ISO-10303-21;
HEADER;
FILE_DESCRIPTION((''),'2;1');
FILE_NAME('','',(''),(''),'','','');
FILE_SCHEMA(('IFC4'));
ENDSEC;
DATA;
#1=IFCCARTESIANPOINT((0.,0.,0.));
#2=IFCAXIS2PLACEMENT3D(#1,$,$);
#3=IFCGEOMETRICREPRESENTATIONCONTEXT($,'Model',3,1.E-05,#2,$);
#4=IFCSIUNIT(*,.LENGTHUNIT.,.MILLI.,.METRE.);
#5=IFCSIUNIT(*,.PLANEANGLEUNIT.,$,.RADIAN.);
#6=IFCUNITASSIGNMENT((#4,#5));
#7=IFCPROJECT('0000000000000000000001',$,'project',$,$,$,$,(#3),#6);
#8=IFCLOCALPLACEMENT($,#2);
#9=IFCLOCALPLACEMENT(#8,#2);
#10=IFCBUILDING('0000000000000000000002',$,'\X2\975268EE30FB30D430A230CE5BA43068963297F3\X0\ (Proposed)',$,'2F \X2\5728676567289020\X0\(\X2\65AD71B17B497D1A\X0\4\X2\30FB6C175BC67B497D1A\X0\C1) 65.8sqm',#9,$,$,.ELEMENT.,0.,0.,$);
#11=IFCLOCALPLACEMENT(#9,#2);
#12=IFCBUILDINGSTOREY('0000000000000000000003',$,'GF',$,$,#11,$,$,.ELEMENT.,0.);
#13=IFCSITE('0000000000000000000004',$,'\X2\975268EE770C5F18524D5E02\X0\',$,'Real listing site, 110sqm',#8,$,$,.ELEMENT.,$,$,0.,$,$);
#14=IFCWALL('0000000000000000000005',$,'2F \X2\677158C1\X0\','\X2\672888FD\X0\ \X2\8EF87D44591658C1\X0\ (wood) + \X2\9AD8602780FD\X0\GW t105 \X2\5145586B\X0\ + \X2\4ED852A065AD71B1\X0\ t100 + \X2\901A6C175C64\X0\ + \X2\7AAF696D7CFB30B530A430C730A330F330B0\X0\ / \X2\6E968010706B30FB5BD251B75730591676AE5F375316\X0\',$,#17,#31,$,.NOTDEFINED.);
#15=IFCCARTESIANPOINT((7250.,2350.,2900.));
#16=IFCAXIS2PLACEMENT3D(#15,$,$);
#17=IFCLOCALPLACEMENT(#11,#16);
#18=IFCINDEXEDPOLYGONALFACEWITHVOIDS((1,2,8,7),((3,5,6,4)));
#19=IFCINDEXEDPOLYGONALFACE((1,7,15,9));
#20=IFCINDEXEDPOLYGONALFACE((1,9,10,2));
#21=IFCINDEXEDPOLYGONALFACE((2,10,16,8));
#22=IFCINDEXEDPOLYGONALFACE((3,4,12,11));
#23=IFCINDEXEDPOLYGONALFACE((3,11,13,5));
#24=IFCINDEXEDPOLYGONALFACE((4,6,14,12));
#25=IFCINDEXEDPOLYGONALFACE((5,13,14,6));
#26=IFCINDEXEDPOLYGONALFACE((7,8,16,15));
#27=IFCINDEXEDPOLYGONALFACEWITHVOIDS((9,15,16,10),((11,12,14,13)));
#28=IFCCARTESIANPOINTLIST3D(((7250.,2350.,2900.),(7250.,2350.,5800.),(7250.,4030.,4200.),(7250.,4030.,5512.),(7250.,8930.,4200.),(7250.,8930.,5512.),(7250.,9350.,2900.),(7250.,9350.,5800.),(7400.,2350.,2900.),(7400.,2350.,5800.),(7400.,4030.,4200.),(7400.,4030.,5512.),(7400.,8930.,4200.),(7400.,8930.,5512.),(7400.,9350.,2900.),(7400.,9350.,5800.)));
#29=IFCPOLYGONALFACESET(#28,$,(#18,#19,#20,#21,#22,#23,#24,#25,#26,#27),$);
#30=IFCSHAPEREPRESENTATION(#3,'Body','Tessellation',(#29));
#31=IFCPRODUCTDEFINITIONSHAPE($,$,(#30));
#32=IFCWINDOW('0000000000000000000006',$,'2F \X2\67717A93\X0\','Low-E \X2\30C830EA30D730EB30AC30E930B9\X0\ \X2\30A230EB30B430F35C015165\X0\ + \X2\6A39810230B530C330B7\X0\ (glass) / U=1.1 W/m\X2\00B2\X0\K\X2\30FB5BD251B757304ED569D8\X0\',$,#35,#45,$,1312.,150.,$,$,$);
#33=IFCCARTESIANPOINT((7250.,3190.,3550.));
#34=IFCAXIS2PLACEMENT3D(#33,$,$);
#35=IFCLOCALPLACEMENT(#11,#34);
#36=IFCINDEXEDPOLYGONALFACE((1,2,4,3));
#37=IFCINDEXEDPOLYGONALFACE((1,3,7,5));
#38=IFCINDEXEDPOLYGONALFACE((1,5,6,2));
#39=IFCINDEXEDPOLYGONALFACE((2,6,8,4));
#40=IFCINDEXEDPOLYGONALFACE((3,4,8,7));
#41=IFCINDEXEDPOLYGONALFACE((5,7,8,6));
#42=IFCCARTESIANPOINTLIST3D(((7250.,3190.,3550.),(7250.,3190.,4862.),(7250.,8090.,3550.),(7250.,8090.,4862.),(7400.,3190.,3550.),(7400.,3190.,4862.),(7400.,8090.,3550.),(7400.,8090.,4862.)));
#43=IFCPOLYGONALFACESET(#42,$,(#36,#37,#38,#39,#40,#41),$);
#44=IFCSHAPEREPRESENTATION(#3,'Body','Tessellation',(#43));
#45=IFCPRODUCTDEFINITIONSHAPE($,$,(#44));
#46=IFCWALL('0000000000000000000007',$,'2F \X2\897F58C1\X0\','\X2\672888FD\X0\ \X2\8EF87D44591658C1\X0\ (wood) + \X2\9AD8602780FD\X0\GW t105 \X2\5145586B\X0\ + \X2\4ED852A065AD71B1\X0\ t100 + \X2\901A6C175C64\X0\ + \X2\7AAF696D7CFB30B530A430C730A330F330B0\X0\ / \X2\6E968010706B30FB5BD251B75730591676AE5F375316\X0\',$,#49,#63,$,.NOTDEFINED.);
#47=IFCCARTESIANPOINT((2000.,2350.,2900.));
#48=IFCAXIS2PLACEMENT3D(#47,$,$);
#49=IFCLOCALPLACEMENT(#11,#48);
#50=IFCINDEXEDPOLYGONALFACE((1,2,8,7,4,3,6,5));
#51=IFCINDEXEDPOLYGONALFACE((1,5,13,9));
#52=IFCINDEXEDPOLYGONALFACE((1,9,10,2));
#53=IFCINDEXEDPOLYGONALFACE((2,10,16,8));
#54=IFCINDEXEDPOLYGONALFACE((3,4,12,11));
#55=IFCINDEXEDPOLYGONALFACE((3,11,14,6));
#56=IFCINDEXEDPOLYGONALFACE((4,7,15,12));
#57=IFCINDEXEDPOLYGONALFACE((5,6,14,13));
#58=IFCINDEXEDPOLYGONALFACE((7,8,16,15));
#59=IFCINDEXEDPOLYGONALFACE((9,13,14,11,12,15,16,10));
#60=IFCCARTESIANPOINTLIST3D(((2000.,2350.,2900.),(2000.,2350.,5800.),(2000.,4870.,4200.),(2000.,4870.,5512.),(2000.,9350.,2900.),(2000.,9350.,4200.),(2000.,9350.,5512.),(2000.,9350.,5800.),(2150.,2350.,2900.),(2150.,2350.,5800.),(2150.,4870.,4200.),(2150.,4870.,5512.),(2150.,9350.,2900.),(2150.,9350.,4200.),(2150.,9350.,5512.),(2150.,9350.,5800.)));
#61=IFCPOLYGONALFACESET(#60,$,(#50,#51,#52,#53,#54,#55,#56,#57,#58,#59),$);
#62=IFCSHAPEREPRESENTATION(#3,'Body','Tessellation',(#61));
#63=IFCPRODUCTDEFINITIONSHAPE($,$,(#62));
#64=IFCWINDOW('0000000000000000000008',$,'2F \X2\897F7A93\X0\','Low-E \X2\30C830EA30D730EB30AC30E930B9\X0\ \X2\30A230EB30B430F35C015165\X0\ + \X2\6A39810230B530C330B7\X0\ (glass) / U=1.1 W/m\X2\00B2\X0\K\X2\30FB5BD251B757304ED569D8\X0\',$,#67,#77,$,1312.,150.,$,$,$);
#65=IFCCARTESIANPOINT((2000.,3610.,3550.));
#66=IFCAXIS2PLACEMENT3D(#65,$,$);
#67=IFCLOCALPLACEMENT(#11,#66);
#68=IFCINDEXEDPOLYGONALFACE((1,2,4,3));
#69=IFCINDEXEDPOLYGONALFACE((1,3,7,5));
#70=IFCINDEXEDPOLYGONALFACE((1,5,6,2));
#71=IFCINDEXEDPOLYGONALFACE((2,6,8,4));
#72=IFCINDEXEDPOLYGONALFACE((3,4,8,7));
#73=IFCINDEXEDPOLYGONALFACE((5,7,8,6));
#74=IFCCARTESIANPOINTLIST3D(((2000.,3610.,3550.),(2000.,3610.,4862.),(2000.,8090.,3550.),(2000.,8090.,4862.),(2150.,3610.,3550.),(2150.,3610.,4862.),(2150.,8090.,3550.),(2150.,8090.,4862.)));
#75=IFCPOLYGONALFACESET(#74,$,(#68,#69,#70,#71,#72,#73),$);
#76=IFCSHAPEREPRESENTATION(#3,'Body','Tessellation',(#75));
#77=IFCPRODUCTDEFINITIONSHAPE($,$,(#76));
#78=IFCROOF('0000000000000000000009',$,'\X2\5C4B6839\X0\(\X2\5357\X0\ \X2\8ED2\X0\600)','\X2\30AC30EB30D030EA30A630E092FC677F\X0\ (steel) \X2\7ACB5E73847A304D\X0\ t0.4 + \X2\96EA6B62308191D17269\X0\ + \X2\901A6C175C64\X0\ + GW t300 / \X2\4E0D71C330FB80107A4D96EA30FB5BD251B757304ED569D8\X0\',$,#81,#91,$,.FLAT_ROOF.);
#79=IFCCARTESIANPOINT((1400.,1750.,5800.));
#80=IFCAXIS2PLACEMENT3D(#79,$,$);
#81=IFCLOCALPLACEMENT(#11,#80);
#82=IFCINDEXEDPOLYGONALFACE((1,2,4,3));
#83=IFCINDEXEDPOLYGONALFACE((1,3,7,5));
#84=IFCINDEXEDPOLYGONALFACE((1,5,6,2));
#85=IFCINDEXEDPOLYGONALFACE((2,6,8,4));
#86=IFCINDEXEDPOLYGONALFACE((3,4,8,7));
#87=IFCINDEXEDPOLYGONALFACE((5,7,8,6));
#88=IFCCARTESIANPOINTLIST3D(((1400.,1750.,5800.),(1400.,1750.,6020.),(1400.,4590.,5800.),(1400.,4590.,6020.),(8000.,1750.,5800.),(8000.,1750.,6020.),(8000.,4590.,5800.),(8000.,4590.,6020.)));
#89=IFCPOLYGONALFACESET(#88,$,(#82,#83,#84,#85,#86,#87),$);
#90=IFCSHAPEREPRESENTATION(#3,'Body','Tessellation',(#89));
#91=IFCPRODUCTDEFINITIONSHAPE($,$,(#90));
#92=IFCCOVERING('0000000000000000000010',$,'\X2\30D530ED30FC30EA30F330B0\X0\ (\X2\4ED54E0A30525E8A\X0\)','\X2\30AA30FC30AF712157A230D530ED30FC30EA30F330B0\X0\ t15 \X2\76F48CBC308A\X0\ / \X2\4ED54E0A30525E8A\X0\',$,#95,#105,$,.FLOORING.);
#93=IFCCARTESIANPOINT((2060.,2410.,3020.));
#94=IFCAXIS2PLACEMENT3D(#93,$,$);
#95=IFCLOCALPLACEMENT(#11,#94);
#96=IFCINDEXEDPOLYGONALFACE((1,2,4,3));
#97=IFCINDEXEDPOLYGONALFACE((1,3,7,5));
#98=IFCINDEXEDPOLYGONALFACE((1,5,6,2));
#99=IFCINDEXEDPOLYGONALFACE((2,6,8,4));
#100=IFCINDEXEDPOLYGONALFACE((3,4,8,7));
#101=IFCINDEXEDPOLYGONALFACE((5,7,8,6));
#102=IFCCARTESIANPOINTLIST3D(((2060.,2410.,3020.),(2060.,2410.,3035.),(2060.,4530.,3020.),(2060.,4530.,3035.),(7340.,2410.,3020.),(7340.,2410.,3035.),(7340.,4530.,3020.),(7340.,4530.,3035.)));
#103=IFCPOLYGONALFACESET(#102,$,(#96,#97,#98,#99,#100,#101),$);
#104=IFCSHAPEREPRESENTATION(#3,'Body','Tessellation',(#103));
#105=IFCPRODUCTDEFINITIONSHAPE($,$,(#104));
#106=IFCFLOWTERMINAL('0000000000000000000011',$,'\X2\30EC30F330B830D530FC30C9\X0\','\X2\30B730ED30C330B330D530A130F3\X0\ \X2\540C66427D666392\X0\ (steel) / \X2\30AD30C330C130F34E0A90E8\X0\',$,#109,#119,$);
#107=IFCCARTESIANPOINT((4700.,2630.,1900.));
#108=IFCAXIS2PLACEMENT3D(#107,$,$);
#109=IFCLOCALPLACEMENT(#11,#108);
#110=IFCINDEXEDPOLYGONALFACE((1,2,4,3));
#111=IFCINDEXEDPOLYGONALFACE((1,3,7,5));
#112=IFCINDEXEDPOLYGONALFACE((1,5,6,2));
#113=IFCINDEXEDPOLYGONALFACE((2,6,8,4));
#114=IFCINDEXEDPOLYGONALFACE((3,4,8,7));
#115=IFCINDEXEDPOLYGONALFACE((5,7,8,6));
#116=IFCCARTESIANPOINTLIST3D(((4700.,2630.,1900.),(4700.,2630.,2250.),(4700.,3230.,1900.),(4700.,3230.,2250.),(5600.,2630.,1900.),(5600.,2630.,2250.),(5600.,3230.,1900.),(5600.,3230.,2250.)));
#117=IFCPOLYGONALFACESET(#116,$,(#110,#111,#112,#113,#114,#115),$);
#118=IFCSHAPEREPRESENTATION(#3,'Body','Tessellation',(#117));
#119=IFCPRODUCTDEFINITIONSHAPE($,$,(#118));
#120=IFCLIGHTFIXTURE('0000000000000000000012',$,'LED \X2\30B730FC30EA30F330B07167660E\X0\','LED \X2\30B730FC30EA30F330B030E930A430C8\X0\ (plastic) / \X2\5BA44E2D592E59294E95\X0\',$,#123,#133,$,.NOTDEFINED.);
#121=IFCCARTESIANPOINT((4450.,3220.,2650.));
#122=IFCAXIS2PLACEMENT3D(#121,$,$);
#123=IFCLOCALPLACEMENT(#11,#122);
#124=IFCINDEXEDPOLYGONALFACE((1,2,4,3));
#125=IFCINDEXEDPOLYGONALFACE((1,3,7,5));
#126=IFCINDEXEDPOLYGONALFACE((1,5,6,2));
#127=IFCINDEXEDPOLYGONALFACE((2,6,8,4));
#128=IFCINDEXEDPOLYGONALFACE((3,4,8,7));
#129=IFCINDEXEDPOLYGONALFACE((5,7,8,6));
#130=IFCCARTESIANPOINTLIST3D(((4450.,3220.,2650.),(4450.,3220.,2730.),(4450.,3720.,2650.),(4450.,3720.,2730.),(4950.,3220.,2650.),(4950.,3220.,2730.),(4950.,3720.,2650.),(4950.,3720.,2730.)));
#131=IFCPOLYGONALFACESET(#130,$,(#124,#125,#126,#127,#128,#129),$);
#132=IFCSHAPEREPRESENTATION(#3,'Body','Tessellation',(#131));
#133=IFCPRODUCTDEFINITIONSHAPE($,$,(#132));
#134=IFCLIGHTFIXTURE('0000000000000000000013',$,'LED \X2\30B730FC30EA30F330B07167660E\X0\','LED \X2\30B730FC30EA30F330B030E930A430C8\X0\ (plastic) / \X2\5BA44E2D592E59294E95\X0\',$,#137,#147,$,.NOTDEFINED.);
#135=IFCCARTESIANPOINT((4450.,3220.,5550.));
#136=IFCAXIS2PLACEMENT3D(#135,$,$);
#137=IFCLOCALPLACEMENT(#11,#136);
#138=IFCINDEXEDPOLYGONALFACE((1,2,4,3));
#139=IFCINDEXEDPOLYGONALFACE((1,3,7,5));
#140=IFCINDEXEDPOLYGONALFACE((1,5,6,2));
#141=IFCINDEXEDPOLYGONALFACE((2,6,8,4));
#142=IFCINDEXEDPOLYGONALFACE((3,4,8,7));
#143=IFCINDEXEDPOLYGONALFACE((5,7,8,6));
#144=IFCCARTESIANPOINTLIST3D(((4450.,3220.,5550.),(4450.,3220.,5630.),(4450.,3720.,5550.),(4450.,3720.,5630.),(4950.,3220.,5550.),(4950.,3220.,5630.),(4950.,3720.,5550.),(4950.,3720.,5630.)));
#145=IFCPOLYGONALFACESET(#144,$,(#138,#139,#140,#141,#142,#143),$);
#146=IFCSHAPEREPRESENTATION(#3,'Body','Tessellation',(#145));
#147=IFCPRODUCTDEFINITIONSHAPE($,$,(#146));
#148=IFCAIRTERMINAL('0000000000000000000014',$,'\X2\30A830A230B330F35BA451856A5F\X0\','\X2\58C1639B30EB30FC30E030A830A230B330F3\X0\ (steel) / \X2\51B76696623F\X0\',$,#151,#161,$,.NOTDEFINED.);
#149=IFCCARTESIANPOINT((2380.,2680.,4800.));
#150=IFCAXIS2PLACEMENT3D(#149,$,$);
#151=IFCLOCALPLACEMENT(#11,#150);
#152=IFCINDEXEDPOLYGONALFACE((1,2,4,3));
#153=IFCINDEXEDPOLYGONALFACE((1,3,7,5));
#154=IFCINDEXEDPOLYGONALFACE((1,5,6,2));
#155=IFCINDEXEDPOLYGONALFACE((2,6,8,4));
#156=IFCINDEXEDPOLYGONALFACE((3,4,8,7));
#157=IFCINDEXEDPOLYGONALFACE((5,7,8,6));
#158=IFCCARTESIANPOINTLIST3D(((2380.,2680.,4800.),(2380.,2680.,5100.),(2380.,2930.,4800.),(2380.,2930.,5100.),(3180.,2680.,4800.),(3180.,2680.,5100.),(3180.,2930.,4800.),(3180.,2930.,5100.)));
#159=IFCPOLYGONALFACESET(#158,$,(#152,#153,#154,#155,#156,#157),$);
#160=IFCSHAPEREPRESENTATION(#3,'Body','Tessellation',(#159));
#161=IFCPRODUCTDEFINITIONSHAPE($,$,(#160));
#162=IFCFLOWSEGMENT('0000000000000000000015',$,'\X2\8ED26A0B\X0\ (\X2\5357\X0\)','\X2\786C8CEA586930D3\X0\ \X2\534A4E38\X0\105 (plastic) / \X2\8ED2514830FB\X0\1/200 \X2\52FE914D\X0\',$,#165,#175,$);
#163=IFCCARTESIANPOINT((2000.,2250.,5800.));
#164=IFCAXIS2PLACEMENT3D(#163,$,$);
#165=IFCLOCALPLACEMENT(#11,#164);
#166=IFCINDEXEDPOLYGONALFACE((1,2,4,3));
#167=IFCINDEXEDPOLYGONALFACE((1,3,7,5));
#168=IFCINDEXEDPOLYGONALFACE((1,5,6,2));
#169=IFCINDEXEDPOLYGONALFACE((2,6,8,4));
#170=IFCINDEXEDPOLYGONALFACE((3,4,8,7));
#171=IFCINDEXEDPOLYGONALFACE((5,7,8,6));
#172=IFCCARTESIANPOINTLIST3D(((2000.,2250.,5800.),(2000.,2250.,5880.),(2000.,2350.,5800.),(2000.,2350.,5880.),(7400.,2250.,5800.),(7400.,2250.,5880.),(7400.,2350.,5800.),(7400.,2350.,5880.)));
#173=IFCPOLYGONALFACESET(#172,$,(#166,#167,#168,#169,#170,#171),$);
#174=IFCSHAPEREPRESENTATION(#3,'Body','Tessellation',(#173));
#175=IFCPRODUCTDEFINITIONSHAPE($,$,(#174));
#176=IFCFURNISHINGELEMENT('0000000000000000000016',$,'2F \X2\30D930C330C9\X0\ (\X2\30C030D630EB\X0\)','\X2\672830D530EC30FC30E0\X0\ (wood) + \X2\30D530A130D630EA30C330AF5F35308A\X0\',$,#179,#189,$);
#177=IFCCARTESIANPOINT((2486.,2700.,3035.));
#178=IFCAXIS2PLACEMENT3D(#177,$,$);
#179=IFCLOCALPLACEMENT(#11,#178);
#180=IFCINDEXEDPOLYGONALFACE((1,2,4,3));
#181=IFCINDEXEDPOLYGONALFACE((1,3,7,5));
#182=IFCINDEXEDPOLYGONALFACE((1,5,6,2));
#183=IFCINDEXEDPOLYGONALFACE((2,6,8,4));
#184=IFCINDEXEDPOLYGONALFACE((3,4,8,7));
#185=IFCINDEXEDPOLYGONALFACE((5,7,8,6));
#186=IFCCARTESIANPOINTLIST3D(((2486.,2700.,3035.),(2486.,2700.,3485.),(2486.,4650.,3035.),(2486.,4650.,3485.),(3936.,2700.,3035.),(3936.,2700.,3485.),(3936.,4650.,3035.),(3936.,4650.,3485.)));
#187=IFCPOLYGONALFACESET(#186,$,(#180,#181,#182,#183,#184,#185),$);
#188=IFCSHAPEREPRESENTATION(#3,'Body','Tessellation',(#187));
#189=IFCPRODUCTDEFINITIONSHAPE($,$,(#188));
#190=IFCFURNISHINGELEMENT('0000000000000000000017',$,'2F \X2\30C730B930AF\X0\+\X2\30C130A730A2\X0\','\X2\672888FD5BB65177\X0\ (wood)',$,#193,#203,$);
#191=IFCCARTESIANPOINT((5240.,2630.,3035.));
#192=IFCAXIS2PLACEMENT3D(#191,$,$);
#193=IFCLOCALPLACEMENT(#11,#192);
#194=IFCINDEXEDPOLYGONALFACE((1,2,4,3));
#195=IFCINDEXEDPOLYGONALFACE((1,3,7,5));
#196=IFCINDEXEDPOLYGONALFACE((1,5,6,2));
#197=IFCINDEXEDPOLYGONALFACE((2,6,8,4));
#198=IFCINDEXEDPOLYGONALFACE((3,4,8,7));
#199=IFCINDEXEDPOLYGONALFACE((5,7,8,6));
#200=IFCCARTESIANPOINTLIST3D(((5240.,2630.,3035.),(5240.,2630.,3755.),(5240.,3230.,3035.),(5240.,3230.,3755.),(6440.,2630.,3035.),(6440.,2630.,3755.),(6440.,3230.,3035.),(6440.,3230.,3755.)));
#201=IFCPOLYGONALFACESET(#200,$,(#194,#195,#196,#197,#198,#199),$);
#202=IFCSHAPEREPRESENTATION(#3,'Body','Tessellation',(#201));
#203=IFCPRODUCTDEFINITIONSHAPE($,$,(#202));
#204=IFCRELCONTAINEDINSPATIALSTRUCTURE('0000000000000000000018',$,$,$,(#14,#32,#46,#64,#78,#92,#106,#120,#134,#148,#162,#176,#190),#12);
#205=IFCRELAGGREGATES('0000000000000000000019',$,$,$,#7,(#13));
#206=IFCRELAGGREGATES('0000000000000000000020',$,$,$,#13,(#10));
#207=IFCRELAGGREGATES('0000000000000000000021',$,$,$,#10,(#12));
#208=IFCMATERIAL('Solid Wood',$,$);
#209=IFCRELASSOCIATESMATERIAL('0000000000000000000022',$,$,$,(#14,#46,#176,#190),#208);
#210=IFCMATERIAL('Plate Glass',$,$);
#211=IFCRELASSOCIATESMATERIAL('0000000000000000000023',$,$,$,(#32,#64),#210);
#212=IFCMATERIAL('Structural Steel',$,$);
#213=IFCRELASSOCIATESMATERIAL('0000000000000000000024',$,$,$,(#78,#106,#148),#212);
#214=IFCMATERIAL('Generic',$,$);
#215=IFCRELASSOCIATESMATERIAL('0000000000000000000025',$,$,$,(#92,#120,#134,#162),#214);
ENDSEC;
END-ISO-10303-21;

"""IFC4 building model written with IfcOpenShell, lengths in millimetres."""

from ifc_helpers import new_model, si_unit, frame, frame_2d, origin, place, context, project, spatial, rectangle, extrude, material, element, fill, save


model = new_model("IFC4")

# Units and contexts
model_context = context("Model", 3, precision=1e-05, world=origin())
ifc_project = project(units=[si_unit("LENGTHUNIT", "METRE", prefix="MILLI"), si_unit("PLANEANGLEUNIT", "RADIAN")], contexts=[model_context])

# Site, building, storey
site_placement = place(None, origin())
site = spatial("IfcSite", under=ifc_project, at=site_placement, Name="青森県弘前市", ObjectType="Real listing site, 110sqm", CompositionType="ELEMENT", RefElevation=0.0)
building_placement = place(site_placement, origin())
building = spatial("IfcBuilding", under=site, at=building_placement, Name="青森・ピアノ室と防音 (Proposed)", ObjectType="2F 在来木造(断熱等級4・気密等級C1) 65.8sqm", CompositionType="ELEMENT", ElevationOfRefHeight=0.0, ElevationOfTerrain=0.0)
storey_placement = place(building_placement, origin())
storey = spatial("IfcBuildingStorey", under=building, at=storey_placement, Name="GF", CompositionType="ELEMENT", Elevation=0.0)

# Shared definitions
ifc_material_1 = material(Name="Solid Wood")

# Shared definitions
ifc_material_2 = material(Name="Plate Glass")

# Walls, openings, windows
wall_1_placement = place(storey_placement, frame((7250.0, 2350.0, 2900.0)))
wall_1 = element("IfcWall", 1, at=wall_1_placement, inside=storey, material=ifc_material_1, Name="2F 東壁", Description="木製 軸組外壁 (wood) + 高性能GW t105 充填 + 付加断熱 t100 + 通気層 + 窯業系サイディング / 準耐火・寒冷地外皮強化", PredefinedType="NOTDEFINED", context=model_context, shape_type="SweptSolid", body=[
    extrude(rectangle(XDim=150.0, YDim=7000.0, at=frame_2d((75.0, 3500.0))), frame((7250.0, 2350.0, 2900.0)), (0.0, 0.0, 1.0), 2900.0),
])
opening_1_placement = place(storey_placement, frame((7250.0, 3190.0, 3550.0)))
opening_1 = element("IfcOpeningElement", 2, at=opening_1_placement, cuts=wall_1, PredefinedType="NOTDEFINED", context=model_context, shape_type="SweptSolid", body=[
    extrude(rectangle(XDim=150.0, YDim=4900.0, at=frame_2d((75.0, 2450.0))), frame((7250.0, 3190.0, 3550.0)), (0.0, 0.0, 1.0), 1312.0),
])
window_1_placement = place(storey_placement, frame((7250.0, 3190.0, 3550.0)))
window_1 = element("IfcWindow", 3, at=window_1_placement, inside=storey, material=ifc_material_2, Name="2F 東窓", Description="Low-E トリプルガラス アルゴン封入 + 樹脂サッシ (glass) / U=1.1 W/m²K・寒冷地仕様", OverallHeight=1312.0, OverallWidth=150.0, context=model_context, shape_type="SweptSolid", body=[
    extrude(rectangle(XDim=150.0, YDim=4900.0, at=frame_2d((75.0, 2450.0))), frame((7250.0, 3190.0, 3550.0)), (0.0, 0.0, 1.0), 1312.0),
])
fill(opening_1, window_1)
wall_2_placement = place(storey_placement, frame((2000.0, 2350.0, 2900.0)))
wall_2 = element("IfcWall", 4, at=wall_2_placement, inside=storey, material=ifc_material_1, Name="2F 西壁", Description="木製 軸組外壁 (wood) + 高性能GW t105 充填 + 付加断熱 t100 + 通気層 + 窯業系サイディング / 準耐火・寒冷地外皮強化", PredefinedType="NOTDEFINED", context=model_context, shape_type="SweptSolid", body=[
    extrude(rectangle(XDim=150.0, YDim=7000.0, at=frame_2d((75.0, 3500.0))), frame((2000.0, 2350.0, 2900.0)), (0.0, 0.0, 1.0), 2900.0),
])
opening_2_placement = place(storey_placement, frame((2000.0, 3610.0, 3550.0)))
opening_2 = element("IfcOpeningElement", 5, at=opening_2_placement, cuts=wall_2, PredefinedType="NOTDEFINED", context=model_context, shape_type="SweptSolid", body=[
    extrude(rectangle(XDim=150.0, YDim=4480.0, at=frame_2d((75.0, 2240.0))), frame((2000.0, 3610.0, 3550.0)), (0.0, 0.0, 1.0), 1312.0),
])
window_2_placement = place(storey_placement, frame((2000.0, 3610.0, 3550.0)))
window_2 = element("IfcWindow", 6, at=window_2_placement, inside=storey, material=ifc_material_2, Name="2F 西窓", Description="Low-E トリプルガラス アルゴン封入 + 樹脂サッシ (glass) / U=1.1 W/m²K・寒冷地仕様", OverallHeight=1312.0, OverallWidth=150.0, context=model_context, shape_type="SweptSolid", body=[
    extrude(rectangle(XDim=150.0, YDim=4480.0, at=frame_2d((75.0, 2240.0))), frame((2000.0, 3610.0, 3550.0)), (0.0, 0.0, 1.0), 1312.0),
])
fill(opening_2, window_2)

# Roof
ifc_material_3 = material(Name="Structural Steel")
for number, where, name in (
    (7, (1400.0, 1750.0, 5800.0), "屋根(南 軒600)"),
):
    element("IfcRoof", number, at=place(storey_placement, frame(where)), inside=storey, material=ifc_material_3, Name=name, Description="ガルバリウム鋼板 (steel) 立平葺き t0.4 + 雪止め金物 + 通気層 + GW t300 / 不燃・耐積雪・寒冷地仕様", PredefinedType="FLAT_ROOF", context=model_context, shape_type="SweptSolid", body=[
        extrude(rectangle(XDim=6600.0, YDim=2840.0, at=frame_2d((3300.0, 1420.0))), frame((1400.0, 1750.0, 5800.0)), (0.0, 0.0, 1.0), 220.0),
    ])

# Covering
ifc_material_4 = material(Name="Generic")
covering_placement = place(storey_placement, frame((2060.0, 2410.0, 3020.0)))
element("IfcCovering", 8, at=covering_placement, inside=storey, material=ifc_material_4, Name="フローリング (仕上げ床)", Description="オーク無垢フローリング t15 直貼り / 仕上げ床", PredefinedType="FLOORING", context=model_context, shape_type="SweptSolid", body=[
    extrude(rectangle(XDim=5280.0, YDim=2120.0, at=frame_2d((2640.0, 1060.0))), frame((2060.0, 2410.0, 3020.0)), (0.0, 0.0, 1.0), 15.0),
])

# Flow terminal
flow_terminal_placement = place(storey_placement, frame((4700.0, 2630.0, 1900.0)))
element("IfcFlowTerminal", 9, at=flow_terminal_placement, inside=storey, material=ifc_material_3, Name="レンジフード", Description="シロッコファン 同時給排 (steel) / キッチン上部", context=model_context, shape_type="SweptSolid", body=[
    extrude(rectangle(XDim=900.0, YDim=600.0, at=frame_2d((450.0, 300.0))), frame((4700.0, 2630.0, 1900.0)), (0.0, 0.0, 1.0), 350.0),
])

# Light fixtures
light_fixture_1_placement = place(storey_placement, frame((4450.0, 3220.0, 2650.0)))
element("IfcLightFixture", 10, at=light_fixture_1_placement, inside=storey, material=ifc_material_4, Name="LED シーリング照明", Description="LED シーリングライト (plastic) / 室中央天井", PredefinedType="NOTDEFINED", context=model_context, shape_type="SweptSolid", body=[
    extrude(rectangle(XDim=500.0, YDim=500.0, at=frame_2d((250.0, 250.0))), frame((4450.0, 3220.0, 2650.0)), (0.0, 0.0, 1.0), 80.0),
])
light_fixture_2_placement = place(storey_placement, frame((4450.0, 3220.0, 5550.0)))
element("IfcLightFixture", 11, at=light_fixture_2_placement, inside=storey, material=ifc_material_4, Name="LED シーリング照明", Description="LED シーリングライト (plastic) / 室中央天井", PredefinedType="NOTDEFINED", context=model_context, shape_type="SweptSolid", body=[
    extrude(rectangle(XDim=500.0, YDim=500.0, at=frame_2d((250.0, 250.0))), frame((4450.0, 3220.0, 5550.0)), (0.0, 0.0, 1.0), 80.0),
])

# Air terminal
air_terminal_placement = place(storey_placement, frame((2380.0, 2680.0, 4800.0)))
element("IfcAirTerminal", 12, at=air_terminal_placement, inside=storey, material=ifc_material_3, Name="エアコン室内機", Description="壁掛ルームエアコン (steel) / 冷暖房", PredefinedType="NOTDEFINED", context=model_context, shape_type="SweptSolid", body=[
    extrude(rectangle(XDim=800.0, YDim=250.0, at=frame_2d((400.0, 125.0))), frame((2380.0, 2680.0, 4800.0)), (0.0, 0.0, 1.0), 300.0),
])

# Flow segment
flow_segment_placement = place(storey_placement, frame((2000.0, 2250.0, 5800.0)))
element("IfcFlowSegment", 13, at=flow_segment_placement, inside=storey, material=ifc_material_4, Name="軒樋 (南)", Description="硬質塩ビ 半丸105 (plastic) / 軒先・1/200 勾配", context=model_context, shape_type="SweptSolid", body=[
    extrude(rectangle(XDim=5400.0, YDim=100.0, at=frame_2d((2700.0, 50.0))), frame((2000.0, 2250.0, 5800.0)), (0.0, 0.0, 1.0), 80.0),
])

# Furnishing elements
furnishing_1_placement = place(storey_placement, frame((2486.0, 2700.0, 3035.0)))
element("IfcFurnishingElement", 14, at=furnishing_1_placement, inside=storey, material=ifc_material_1, Name="2F ベッド (ダブル)", Description="木フレーム (wood) + ファブリック張り", context=model_context, shape_type="SweptSolid", body=[
    extrude(rectangle(XDim=1450.0, YDim=1950.0, at=frame_2d((725.0, 975.0))), frame((2486.0, 2700.0, 3035.0)), (0.0, 0.0, 1.0), 450.0),
])
furnishing_2_placement = place(storey_placement, frame((5240.0, 2630.0, 3035.0)))
element("IfcFurnishingElement", 15, at=furnishing_2_placement, inside=storey, material=ifc_material_1, Name="2F デスク+チェア", Description="木製家具 (wood)", context=model_context, shape_type="SweptSolid", body=[
    extrude(rectangle(XDim=1200.0, YDim=600.0, at=frame_2d((600.0, 300.0))), frame((5240.0, 2630.0, 3035.0)), (0.0, 0.0, 1.0), 720.0),
])

save(model, "model.ifc")
